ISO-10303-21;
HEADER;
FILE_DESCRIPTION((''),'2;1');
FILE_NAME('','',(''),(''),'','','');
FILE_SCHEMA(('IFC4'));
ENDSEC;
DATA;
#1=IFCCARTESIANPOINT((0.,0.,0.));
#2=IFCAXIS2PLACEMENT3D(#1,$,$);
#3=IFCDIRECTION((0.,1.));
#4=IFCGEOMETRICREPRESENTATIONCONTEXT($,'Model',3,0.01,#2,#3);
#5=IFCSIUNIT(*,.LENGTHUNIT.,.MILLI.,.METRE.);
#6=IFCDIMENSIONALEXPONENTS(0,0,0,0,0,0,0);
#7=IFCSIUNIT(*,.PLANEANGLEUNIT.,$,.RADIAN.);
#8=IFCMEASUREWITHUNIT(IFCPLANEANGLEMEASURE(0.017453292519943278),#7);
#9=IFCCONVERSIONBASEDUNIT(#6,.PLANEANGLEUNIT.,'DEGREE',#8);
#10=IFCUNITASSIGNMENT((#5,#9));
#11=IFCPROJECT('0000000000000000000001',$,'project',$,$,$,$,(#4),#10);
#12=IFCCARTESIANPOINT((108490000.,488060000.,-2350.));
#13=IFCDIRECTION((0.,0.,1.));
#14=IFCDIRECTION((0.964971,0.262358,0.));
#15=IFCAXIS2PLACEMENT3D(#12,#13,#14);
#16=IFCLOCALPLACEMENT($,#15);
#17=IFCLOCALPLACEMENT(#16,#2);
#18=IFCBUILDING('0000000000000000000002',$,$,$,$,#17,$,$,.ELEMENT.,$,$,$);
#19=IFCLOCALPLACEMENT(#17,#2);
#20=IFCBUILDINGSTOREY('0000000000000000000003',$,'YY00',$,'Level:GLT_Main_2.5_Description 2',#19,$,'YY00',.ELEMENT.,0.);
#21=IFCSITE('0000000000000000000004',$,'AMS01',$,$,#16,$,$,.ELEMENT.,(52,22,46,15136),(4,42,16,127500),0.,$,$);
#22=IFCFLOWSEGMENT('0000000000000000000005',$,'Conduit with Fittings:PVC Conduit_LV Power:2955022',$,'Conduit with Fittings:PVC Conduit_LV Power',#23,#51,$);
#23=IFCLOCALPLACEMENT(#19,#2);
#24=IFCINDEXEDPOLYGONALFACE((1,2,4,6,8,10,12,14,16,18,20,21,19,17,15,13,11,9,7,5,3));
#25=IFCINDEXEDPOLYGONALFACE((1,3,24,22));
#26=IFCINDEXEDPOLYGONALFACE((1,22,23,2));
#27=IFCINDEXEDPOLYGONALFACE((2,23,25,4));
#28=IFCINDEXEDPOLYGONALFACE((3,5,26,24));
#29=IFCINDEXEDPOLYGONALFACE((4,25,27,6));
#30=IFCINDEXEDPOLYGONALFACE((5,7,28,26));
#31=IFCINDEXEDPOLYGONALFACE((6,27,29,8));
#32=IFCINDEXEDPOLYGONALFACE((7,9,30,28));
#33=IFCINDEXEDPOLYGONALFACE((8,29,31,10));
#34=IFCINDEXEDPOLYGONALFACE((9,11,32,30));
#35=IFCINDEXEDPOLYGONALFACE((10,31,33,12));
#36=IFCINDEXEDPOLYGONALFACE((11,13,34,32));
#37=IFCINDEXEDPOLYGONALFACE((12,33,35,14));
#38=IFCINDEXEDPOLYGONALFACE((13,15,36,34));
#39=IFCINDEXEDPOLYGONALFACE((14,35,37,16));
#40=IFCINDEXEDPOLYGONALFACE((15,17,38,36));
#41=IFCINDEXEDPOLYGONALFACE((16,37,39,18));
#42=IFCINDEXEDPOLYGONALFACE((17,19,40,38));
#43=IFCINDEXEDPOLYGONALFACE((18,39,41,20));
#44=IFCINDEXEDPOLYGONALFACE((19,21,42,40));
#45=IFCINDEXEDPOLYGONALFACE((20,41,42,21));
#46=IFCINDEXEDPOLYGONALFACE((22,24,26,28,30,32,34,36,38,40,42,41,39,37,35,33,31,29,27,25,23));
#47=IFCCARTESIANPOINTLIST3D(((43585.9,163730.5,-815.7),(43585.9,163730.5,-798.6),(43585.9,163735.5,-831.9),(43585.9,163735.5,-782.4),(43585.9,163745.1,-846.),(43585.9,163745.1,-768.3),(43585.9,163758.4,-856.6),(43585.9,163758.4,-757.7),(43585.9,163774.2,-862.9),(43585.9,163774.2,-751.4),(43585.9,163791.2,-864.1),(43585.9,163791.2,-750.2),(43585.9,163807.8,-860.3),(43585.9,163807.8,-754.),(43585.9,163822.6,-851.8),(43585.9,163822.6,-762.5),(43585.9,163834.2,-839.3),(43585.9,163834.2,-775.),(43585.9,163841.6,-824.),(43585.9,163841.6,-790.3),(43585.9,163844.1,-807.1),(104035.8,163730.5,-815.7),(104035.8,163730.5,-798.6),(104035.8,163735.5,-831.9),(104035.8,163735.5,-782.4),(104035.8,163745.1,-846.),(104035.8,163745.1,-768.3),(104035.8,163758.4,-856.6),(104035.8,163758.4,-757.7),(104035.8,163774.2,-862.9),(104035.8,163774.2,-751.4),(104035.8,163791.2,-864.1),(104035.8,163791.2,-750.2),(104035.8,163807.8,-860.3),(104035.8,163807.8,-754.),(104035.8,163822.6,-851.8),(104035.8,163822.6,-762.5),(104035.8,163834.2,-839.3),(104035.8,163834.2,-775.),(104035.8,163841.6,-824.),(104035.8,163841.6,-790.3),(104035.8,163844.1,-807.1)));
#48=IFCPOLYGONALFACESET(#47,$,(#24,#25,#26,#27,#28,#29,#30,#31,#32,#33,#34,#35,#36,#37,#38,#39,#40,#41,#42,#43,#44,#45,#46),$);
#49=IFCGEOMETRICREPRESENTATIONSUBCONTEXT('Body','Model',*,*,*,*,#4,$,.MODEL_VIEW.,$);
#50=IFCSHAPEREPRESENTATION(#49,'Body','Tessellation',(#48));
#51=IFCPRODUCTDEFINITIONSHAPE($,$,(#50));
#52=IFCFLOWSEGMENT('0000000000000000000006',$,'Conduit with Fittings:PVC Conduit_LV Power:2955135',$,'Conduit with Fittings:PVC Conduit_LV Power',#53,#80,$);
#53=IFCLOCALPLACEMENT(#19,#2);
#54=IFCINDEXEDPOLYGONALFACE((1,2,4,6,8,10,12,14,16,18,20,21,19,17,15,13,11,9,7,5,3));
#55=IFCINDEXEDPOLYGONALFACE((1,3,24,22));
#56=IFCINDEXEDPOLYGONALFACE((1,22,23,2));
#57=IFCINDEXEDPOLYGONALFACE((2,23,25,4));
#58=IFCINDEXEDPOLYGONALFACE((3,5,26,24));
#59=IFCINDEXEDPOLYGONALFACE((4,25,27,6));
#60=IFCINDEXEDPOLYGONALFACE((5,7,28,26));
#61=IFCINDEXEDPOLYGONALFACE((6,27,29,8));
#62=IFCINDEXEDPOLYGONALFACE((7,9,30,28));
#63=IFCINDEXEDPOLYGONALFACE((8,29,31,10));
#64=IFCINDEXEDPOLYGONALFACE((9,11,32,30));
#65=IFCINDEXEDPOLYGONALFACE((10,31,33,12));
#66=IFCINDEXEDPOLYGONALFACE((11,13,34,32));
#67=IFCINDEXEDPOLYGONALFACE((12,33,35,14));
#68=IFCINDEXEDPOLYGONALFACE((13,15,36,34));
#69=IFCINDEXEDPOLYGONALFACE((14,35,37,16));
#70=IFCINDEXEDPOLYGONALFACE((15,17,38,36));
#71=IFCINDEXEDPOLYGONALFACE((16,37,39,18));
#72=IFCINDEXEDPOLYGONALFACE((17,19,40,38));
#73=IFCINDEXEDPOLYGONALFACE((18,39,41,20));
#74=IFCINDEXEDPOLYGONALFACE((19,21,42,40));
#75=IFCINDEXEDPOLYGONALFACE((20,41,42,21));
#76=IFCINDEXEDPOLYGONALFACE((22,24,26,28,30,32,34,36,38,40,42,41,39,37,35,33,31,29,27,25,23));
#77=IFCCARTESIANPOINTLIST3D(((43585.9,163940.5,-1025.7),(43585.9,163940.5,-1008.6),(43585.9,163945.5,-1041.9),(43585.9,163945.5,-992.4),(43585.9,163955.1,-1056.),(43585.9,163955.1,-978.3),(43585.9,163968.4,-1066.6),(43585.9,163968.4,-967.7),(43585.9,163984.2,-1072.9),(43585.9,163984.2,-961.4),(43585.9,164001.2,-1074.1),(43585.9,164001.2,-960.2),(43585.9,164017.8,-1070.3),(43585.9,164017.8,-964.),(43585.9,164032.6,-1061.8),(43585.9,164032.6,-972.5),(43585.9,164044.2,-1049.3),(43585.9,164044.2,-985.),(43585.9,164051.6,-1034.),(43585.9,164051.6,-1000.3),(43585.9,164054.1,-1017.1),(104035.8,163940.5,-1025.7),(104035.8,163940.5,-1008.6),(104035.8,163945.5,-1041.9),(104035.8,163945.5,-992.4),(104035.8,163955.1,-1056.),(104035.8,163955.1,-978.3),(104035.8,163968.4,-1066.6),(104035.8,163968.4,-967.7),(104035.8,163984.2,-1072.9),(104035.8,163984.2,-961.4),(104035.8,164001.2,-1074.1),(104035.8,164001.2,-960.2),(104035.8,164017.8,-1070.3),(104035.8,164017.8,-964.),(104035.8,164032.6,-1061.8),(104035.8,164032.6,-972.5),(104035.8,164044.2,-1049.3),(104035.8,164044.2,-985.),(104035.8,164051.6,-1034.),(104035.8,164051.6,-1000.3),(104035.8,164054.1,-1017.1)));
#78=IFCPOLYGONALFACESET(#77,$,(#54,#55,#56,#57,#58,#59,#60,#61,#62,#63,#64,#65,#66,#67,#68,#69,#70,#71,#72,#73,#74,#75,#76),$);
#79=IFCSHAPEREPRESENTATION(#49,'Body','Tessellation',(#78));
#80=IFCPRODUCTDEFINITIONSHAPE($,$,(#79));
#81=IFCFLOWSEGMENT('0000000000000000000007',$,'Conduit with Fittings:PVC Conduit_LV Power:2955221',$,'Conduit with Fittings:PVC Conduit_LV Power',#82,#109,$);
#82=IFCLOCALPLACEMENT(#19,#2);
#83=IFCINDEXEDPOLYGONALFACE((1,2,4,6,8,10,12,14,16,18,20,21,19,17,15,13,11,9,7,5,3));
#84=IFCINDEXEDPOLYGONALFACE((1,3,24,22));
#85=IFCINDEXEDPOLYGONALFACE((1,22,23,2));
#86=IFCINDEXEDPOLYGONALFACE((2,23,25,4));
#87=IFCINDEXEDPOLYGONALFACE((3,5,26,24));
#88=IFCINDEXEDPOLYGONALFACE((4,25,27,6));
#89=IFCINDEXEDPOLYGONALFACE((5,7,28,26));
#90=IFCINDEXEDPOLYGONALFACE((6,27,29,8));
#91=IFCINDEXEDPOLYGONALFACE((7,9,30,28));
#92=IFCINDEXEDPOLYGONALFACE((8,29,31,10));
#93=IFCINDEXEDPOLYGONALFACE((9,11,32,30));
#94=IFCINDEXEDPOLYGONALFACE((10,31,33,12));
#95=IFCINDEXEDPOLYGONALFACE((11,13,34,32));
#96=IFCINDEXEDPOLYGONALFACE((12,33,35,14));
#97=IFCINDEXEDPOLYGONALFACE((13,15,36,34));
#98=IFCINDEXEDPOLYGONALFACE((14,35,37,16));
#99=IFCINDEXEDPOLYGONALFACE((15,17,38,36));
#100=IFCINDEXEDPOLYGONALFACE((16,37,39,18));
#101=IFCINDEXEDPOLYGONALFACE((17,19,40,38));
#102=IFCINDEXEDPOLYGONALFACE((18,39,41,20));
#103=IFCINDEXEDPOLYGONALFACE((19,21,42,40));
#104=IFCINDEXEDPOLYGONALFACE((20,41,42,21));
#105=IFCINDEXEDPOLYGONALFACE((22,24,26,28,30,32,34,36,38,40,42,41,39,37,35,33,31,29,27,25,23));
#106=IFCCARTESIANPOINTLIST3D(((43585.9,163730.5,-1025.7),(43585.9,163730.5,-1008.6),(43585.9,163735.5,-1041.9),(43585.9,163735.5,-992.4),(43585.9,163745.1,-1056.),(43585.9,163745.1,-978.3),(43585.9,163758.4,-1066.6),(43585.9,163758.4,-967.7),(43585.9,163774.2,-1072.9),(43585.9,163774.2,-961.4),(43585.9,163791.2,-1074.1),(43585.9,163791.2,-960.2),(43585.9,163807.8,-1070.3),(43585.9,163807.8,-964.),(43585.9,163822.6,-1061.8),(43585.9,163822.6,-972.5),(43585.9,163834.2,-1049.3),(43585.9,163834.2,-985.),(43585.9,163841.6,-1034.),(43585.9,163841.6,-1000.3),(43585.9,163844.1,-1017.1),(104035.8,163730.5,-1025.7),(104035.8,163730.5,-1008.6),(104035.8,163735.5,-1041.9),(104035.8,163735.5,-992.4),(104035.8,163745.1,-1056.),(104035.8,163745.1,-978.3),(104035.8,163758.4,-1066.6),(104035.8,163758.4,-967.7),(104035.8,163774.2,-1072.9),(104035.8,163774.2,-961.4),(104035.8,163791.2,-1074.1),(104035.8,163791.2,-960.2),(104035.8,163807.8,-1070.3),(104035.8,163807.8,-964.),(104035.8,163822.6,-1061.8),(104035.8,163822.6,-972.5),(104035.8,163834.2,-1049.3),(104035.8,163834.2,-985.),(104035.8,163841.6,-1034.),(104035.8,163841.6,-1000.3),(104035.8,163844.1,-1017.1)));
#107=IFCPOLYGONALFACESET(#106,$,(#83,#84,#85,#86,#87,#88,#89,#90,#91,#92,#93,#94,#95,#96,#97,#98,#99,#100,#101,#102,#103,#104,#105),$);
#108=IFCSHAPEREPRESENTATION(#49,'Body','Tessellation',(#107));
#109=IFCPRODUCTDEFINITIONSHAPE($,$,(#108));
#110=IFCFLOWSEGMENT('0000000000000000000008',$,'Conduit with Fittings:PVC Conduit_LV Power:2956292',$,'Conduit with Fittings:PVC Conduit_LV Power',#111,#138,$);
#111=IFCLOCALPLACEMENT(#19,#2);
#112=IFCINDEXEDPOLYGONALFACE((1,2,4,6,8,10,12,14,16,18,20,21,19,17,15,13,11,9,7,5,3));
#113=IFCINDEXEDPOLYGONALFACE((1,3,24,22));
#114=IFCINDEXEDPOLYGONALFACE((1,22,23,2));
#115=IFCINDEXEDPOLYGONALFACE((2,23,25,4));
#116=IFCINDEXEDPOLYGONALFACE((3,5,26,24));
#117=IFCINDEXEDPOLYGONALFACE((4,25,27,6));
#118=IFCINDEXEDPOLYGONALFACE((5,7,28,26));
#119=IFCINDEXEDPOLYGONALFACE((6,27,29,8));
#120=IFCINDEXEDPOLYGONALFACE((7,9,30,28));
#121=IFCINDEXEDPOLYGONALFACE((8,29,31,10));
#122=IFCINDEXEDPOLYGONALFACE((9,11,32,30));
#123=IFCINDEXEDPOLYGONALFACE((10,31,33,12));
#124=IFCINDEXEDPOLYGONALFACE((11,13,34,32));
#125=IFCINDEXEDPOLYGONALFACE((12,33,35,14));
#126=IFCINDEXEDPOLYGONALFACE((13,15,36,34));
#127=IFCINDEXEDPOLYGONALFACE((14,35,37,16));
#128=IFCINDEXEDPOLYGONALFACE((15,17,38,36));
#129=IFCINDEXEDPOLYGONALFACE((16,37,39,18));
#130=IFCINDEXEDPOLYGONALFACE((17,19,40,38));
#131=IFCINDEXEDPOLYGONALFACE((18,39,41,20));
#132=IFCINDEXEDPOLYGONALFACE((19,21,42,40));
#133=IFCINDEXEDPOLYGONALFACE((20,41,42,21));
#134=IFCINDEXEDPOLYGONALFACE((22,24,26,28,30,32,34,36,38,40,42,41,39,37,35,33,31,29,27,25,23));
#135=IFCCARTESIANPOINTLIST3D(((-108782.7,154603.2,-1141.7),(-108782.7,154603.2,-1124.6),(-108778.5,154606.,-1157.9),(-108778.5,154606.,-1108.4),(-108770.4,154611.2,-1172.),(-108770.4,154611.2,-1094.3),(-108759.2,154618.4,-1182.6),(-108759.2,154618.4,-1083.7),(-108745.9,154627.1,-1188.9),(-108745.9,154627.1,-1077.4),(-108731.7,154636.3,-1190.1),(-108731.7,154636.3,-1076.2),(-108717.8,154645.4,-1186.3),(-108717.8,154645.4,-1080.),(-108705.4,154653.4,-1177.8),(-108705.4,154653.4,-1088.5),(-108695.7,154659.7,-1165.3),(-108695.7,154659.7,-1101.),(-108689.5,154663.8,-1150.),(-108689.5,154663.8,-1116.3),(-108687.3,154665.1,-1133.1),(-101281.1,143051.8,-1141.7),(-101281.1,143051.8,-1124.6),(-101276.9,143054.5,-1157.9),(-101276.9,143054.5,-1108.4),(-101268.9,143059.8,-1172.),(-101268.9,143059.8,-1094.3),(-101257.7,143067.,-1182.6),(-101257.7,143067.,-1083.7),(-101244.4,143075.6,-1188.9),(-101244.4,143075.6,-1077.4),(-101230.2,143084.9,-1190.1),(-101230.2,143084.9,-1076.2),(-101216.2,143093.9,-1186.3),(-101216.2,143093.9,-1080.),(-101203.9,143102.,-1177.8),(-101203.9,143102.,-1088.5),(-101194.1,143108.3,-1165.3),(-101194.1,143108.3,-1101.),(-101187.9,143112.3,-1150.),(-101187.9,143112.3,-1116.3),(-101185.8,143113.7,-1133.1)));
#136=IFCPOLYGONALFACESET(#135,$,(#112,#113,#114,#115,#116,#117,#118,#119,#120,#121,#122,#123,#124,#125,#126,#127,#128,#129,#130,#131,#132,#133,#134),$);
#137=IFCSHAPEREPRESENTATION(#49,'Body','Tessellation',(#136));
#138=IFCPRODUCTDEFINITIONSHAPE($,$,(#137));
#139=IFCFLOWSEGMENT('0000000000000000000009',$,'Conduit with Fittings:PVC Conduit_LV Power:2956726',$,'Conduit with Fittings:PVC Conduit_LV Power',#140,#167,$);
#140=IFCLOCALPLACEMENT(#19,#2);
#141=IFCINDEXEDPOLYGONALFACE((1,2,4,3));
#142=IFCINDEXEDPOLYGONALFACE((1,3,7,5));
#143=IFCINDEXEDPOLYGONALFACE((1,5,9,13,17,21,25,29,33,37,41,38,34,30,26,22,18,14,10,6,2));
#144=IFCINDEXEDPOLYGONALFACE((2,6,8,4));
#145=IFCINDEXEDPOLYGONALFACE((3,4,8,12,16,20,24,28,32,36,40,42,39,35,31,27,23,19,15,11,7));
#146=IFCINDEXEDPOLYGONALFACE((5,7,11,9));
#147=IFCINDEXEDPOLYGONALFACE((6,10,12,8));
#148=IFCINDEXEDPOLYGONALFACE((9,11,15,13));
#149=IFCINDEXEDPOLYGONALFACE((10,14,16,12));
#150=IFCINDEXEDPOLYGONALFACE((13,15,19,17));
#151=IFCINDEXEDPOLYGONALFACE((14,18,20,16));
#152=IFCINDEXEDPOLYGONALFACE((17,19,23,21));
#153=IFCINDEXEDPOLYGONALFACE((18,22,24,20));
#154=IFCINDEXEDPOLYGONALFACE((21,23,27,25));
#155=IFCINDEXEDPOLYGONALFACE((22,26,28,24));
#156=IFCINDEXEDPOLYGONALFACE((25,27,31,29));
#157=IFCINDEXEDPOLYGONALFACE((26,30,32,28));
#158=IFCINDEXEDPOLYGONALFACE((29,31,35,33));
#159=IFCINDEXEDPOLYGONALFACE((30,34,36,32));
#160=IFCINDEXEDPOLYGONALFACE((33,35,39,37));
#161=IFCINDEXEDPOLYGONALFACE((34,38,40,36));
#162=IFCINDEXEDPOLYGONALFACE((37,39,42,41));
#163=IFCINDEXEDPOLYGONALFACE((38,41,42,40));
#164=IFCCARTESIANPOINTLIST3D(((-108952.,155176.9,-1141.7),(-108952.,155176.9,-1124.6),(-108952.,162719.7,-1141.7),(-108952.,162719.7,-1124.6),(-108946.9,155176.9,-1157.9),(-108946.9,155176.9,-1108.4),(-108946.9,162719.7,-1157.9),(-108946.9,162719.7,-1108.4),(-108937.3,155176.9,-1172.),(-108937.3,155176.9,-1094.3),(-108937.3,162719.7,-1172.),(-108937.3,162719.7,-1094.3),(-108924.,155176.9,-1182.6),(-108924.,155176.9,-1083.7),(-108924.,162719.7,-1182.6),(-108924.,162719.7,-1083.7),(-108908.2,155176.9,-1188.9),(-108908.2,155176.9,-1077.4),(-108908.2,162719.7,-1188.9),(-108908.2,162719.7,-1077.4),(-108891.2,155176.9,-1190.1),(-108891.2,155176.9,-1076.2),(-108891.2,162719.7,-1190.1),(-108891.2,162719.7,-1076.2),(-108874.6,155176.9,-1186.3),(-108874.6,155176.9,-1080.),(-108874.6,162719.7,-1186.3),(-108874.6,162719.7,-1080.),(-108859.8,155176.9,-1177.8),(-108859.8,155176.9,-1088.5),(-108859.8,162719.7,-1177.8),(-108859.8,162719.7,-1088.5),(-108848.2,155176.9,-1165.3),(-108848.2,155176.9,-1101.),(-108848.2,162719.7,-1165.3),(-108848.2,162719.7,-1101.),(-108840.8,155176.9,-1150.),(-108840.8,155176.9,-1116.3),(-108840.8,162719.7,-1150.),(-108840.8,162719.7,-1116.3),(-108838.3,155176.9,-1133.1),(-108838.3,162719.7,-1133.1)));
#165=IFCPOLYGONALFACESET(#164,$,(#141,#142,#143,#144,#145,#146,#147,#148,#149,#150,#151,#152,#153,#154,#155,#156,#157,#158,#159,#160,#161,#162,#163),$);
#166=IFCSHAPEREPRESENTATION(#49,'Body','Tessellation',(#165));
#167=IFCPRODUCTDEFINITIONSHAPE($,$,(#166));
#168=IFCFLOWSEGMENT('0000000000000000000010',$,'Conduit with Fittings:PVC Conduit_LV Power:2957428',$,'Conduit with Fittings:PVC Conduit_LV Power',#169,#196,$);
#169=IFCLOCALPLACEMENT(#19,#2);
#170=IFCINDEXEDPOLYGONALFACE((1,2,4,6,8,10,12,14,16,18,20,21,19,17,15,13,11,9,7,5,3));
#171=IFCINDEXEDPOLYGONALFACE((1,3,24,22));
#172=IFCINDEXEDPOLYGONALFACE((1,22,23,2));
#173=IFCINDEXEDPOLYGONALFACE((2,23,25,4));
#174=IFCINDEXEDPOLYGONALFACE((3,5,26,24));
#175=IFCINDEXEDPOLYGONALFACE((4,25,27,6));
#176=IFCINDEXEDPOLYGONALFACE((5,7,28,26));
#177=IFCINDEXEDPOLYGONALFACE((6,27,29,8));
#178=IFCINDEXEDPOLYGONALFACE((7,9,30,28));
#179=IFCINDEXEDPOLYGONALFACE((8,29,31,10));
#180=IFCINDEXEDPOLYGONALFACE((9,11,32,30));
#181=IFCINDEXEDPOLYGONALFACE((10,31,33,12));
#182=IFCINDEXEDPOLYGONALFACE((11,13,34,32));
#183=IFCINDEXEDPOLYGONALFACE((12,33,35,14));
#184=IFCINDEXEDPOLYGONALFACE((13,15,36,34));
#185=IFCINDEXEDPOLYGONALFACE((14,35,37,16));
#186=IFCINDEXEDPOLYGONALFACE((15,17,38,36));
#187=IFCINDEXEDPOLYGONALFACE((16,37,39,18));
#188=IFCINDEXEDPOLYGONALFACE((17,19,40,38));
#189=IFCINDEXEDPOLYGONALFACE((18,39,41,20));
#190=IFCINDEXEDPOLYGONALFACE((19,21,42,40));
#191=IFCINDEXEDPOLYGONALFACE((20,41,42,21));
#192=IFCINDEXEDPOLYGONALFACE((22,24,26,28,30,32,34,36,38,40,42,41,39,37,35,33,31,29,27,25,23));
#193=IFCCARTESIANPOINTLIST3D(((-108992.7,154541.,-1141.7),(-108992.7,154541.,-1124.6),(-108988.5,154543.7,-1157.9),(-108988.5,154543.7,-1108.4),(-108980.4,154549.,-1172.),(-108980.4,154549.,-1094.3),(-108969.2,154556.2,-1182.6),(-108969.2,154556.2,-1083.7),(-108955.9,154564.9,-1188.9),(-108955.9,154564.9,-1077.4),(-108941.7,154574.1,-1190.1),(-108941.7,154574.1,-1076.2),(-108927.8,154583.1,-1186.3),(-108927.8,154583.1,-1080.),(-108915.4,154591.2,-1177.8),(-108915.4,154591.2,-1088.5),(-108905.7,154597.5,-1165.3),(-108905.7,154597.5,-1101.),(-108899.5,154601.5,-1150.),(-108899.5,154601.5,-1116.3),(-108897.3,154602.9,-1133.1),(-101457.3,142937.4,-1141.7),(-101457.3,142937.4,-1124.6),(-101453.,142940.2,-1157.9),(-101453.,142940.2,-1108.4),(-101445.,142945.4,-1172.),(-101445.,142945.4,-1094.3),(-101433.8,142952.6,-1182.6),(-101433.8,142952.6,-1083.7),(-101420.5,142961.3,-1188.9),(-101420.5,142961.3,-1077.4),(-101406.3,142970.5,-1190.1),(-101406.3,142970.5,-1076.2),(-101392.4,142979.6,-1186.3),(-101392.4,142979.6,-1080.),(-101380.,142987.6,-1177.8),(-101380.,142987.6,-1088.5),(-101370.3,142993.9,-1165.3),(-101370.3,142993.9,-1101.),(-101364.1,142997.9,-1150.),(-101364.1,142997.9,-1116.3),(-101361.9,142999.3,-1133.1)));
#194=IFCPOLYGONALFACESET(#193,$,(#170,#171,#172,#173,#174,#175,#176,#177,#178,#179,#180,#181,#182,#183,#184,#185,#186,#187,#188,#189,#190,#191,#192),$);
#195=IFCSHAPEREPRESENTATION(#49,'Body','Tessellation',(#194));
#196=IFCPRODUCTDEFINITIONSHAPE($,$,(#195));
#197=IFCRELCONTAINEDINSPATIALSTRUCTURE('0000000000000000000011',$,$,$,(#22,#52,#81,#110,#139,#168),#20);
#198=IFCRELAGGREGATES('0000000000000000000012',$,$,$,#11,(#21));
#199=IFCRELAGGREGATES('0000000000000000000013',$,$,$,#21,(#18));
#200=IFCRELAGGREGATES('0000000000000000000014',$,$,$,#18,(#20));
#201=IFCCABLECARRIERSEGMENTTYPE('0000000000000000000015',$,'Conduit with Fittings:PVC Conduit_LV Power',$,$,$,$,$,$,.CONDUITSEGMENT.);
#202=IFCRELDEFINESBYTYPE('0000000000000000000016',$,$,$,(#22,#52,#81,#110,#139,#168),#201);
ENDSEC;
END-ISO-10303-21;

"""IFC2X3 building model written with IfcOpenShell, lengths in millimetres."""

from ifc_helpers import new_model, entity, si_unit, converted_unit, direction, frame, frame_2d, origin, origin_2d_with_axis, place, context, subcontext, project, spatial, circle, extrude, type_object, element, save


model = new_model("IFC2X3")

# Units and contexts
model_context = context("Model", 3, precision=0.01, world=origin(), true_north=direction((0.0, 1.0)))
body_context = subcontext(model_context, "Body", "Model", "MODEL_VIEW")
ifc_project = project(units=[si_unit("LENGTHUNIT", "METRE", prefix="MILLI"), converted_unit("PLANEANGLEUNIT", "DEGREE", entity("IfcPlaneAngleMeasure", 0.017453292519943278), si_unit("PLANEANGLEUNIT", "RADIAN"), dimensions=[0, 0, 0, 0, 0, 0, 0])], contexts=[model_context])

# Site, building, storey
site_placement = place(None, frame((108490000.0, 488060000.0, -2350.0), z_axis=(0.0, 0.0, 1.0), x_axis=(0.964971, 0.262358, 0.0)))
site = spatial("IfcSite", under=ifc_project, at=site_placement, Name="AMS01", CompositionType="ELEMENT", RefLatitude=(52, 22, 46, 15136), RefLongitude=(4, 42, 16, 127500), RefElevation=0.0)
building_placement = place(site_placement, origin())
building = spatial("IfcBuilding", under=site, at=building_placement, CompositionType="ELEMENT")
storey_placement = place(building_placement, origin())
storey = spatial("IfcBuildingStorey", under=building, at=storey_placement, Name="YY00", ObjectType="Level:GLT_Main_2.5_Description 2", LongName="YY00", CompositionType="ELEMENT", Elevation=0.0)

# Flow segments
cable_carrier_segment_type = type_object("IfcCableCarrierSegmentType", Name="Conduit with Fittings:PVC Conduit_LV Power", PredefinedType="CONDUITSEGMENT")
flow_segment_1_placement = place(storey_placement, origin())
element("IfcFlowSegment", 1, at=flow_segment_1_placement, inside=storey, type_object=cable_carrier_segment_type, Name="Conduit with Fittings:PVC Conduit_LV Power:2955022", ObjectType="Conduit with Fittings:PVC Conduit_LV Power", context=body_context, shape_type="SweptSolid", body=[
    extrude(circle(Radius=57.2, at=frame_2d((0.0, 0.0), x_axis=(1.0, 0.0))), frame((43585.9, 163787.0, -807.1), z_axis=(1.0, 0.0, 0.0), x_axis=(0.0, 1.0, 0.0)), (0.0, 0.0, 1.0), 60450.0),
])
flow_segment_2_placement = place(storey_placement, origin())
element("IfcFlowSegment", 2, at=flow_segment_2_placement, inside=storey, type_object=cable_carrier_segment_type, Name="Conduit with Fittings:PVC Conduit_LV Power:2955135", ObjectType="Conduit with Fittings:PVC Conduit_LV Power", context=body_context, shape_type="SweptSolid", body=[
    extrude(circle(Radius=57.2, at=frame_2d((0.0, 0.0), x_axis=(1.0, 0.0))), frame((43585.9, 163997.0, -1017.1), z_axis=(1.0, 0.0, 0.0), x_axis=(0.0, 1.0, 0.0)), (0.0, 0.0, 1.0), 60450.0),
])
flow_segment_3_placement = place(storey_placement, origin())
element("IfcFlowSegment", 3, at=flow_segment_3_placement, inside=storey, type_object=cable_carrier_segment_type, Name="Conduit with Fittings:PVC Conduit_LV Power:2955221", ObjectType="Conduit with Fittings:PVC Conduit_LV Power", context=body_context, shape_type="SweptSolid", body=[
    extrude(circle(Radius=57.2, at=frame_2d((0.0, 0.0), x_axis=(1.0, 0.0))), frame((43585.9, 163787.0, -1017.1), z_axis=(1.0, 0.0, 0.0), x_axis=(0.0, 1.0, 0.0)), (0.0, 0.0, 1.0), 60450.0),
])
flow_segment_4_placement = place(storey_placement, origin())
element("IfcFlowSegment", 4, at=flow_segment_4_placement, inside=storey, type_object=cable_carrier_segment_type, Name="Conduit with Fittings:PVC Conduit_LV Power:2956292", ObjectType="Conduit with Fittings:PVC Conduit_LV Power", context=body_context, shape_type="SweptSolid", body=[
    extrude(circle(Radius=57.2, at=origin_2d_with_axis()), frame((-101233.7, 143082.6, -1133.1), z_axis=(-0.544636, 0.838673, 0.0), x_axis=(0.838673, 0.544636, 0.0)), (0.0, 0.0, 1.0), 13773.5),
])
flow_segment_5_placement = place(storey_placement, origin())
element("IfcFlowSegment", 5, at=flow_segment_5_placement, inside=storey, type_object=cable_carrier_segment_type, Name="Conduit with Fittings:PVC Conduit_LV Power:2956726", ObjectType="Conduit with Fittings:PVC Conduit_LV Power", context=body_context, shape_type="SweptSolid", body=[
    extrude(circle(Radius=57.2, at=origin_2d_with_axis()), frame((-108895.4, 155176.9, -1133.1), z_axis=(0.0, 1.0, 0.0), x_axis=(1.0, 0.0, 0.0)), (0.0, 0.0, 1.0), 7542.8),
])
flow_segment_6_placement = place(storey_placement, origin())
element("IfcFlowSegment", 6, at=flow_segment_6_placement, inside=storey, type_object=cable_carrier_segment_type, Name="Conduit with Fittings:PVC Conduit_LV Power:2957428", ObjectType="Conduit with Fittings:PVC Conduit_LV Power", context=body_context, shape_type="SweptSolid", body=[
    extrude(circle(Radius=57.2, at=origin_2d_with_axis()), frame((-108945.3, 154571.8, -1133.1), z_axis=(0.544637, -0.838672, 0.0), x_axis=(0.838672, 0.544637, 0.0)), (0.0, 0.0, 1.0), 13835.7),
])

save(model, "model.ifc")
